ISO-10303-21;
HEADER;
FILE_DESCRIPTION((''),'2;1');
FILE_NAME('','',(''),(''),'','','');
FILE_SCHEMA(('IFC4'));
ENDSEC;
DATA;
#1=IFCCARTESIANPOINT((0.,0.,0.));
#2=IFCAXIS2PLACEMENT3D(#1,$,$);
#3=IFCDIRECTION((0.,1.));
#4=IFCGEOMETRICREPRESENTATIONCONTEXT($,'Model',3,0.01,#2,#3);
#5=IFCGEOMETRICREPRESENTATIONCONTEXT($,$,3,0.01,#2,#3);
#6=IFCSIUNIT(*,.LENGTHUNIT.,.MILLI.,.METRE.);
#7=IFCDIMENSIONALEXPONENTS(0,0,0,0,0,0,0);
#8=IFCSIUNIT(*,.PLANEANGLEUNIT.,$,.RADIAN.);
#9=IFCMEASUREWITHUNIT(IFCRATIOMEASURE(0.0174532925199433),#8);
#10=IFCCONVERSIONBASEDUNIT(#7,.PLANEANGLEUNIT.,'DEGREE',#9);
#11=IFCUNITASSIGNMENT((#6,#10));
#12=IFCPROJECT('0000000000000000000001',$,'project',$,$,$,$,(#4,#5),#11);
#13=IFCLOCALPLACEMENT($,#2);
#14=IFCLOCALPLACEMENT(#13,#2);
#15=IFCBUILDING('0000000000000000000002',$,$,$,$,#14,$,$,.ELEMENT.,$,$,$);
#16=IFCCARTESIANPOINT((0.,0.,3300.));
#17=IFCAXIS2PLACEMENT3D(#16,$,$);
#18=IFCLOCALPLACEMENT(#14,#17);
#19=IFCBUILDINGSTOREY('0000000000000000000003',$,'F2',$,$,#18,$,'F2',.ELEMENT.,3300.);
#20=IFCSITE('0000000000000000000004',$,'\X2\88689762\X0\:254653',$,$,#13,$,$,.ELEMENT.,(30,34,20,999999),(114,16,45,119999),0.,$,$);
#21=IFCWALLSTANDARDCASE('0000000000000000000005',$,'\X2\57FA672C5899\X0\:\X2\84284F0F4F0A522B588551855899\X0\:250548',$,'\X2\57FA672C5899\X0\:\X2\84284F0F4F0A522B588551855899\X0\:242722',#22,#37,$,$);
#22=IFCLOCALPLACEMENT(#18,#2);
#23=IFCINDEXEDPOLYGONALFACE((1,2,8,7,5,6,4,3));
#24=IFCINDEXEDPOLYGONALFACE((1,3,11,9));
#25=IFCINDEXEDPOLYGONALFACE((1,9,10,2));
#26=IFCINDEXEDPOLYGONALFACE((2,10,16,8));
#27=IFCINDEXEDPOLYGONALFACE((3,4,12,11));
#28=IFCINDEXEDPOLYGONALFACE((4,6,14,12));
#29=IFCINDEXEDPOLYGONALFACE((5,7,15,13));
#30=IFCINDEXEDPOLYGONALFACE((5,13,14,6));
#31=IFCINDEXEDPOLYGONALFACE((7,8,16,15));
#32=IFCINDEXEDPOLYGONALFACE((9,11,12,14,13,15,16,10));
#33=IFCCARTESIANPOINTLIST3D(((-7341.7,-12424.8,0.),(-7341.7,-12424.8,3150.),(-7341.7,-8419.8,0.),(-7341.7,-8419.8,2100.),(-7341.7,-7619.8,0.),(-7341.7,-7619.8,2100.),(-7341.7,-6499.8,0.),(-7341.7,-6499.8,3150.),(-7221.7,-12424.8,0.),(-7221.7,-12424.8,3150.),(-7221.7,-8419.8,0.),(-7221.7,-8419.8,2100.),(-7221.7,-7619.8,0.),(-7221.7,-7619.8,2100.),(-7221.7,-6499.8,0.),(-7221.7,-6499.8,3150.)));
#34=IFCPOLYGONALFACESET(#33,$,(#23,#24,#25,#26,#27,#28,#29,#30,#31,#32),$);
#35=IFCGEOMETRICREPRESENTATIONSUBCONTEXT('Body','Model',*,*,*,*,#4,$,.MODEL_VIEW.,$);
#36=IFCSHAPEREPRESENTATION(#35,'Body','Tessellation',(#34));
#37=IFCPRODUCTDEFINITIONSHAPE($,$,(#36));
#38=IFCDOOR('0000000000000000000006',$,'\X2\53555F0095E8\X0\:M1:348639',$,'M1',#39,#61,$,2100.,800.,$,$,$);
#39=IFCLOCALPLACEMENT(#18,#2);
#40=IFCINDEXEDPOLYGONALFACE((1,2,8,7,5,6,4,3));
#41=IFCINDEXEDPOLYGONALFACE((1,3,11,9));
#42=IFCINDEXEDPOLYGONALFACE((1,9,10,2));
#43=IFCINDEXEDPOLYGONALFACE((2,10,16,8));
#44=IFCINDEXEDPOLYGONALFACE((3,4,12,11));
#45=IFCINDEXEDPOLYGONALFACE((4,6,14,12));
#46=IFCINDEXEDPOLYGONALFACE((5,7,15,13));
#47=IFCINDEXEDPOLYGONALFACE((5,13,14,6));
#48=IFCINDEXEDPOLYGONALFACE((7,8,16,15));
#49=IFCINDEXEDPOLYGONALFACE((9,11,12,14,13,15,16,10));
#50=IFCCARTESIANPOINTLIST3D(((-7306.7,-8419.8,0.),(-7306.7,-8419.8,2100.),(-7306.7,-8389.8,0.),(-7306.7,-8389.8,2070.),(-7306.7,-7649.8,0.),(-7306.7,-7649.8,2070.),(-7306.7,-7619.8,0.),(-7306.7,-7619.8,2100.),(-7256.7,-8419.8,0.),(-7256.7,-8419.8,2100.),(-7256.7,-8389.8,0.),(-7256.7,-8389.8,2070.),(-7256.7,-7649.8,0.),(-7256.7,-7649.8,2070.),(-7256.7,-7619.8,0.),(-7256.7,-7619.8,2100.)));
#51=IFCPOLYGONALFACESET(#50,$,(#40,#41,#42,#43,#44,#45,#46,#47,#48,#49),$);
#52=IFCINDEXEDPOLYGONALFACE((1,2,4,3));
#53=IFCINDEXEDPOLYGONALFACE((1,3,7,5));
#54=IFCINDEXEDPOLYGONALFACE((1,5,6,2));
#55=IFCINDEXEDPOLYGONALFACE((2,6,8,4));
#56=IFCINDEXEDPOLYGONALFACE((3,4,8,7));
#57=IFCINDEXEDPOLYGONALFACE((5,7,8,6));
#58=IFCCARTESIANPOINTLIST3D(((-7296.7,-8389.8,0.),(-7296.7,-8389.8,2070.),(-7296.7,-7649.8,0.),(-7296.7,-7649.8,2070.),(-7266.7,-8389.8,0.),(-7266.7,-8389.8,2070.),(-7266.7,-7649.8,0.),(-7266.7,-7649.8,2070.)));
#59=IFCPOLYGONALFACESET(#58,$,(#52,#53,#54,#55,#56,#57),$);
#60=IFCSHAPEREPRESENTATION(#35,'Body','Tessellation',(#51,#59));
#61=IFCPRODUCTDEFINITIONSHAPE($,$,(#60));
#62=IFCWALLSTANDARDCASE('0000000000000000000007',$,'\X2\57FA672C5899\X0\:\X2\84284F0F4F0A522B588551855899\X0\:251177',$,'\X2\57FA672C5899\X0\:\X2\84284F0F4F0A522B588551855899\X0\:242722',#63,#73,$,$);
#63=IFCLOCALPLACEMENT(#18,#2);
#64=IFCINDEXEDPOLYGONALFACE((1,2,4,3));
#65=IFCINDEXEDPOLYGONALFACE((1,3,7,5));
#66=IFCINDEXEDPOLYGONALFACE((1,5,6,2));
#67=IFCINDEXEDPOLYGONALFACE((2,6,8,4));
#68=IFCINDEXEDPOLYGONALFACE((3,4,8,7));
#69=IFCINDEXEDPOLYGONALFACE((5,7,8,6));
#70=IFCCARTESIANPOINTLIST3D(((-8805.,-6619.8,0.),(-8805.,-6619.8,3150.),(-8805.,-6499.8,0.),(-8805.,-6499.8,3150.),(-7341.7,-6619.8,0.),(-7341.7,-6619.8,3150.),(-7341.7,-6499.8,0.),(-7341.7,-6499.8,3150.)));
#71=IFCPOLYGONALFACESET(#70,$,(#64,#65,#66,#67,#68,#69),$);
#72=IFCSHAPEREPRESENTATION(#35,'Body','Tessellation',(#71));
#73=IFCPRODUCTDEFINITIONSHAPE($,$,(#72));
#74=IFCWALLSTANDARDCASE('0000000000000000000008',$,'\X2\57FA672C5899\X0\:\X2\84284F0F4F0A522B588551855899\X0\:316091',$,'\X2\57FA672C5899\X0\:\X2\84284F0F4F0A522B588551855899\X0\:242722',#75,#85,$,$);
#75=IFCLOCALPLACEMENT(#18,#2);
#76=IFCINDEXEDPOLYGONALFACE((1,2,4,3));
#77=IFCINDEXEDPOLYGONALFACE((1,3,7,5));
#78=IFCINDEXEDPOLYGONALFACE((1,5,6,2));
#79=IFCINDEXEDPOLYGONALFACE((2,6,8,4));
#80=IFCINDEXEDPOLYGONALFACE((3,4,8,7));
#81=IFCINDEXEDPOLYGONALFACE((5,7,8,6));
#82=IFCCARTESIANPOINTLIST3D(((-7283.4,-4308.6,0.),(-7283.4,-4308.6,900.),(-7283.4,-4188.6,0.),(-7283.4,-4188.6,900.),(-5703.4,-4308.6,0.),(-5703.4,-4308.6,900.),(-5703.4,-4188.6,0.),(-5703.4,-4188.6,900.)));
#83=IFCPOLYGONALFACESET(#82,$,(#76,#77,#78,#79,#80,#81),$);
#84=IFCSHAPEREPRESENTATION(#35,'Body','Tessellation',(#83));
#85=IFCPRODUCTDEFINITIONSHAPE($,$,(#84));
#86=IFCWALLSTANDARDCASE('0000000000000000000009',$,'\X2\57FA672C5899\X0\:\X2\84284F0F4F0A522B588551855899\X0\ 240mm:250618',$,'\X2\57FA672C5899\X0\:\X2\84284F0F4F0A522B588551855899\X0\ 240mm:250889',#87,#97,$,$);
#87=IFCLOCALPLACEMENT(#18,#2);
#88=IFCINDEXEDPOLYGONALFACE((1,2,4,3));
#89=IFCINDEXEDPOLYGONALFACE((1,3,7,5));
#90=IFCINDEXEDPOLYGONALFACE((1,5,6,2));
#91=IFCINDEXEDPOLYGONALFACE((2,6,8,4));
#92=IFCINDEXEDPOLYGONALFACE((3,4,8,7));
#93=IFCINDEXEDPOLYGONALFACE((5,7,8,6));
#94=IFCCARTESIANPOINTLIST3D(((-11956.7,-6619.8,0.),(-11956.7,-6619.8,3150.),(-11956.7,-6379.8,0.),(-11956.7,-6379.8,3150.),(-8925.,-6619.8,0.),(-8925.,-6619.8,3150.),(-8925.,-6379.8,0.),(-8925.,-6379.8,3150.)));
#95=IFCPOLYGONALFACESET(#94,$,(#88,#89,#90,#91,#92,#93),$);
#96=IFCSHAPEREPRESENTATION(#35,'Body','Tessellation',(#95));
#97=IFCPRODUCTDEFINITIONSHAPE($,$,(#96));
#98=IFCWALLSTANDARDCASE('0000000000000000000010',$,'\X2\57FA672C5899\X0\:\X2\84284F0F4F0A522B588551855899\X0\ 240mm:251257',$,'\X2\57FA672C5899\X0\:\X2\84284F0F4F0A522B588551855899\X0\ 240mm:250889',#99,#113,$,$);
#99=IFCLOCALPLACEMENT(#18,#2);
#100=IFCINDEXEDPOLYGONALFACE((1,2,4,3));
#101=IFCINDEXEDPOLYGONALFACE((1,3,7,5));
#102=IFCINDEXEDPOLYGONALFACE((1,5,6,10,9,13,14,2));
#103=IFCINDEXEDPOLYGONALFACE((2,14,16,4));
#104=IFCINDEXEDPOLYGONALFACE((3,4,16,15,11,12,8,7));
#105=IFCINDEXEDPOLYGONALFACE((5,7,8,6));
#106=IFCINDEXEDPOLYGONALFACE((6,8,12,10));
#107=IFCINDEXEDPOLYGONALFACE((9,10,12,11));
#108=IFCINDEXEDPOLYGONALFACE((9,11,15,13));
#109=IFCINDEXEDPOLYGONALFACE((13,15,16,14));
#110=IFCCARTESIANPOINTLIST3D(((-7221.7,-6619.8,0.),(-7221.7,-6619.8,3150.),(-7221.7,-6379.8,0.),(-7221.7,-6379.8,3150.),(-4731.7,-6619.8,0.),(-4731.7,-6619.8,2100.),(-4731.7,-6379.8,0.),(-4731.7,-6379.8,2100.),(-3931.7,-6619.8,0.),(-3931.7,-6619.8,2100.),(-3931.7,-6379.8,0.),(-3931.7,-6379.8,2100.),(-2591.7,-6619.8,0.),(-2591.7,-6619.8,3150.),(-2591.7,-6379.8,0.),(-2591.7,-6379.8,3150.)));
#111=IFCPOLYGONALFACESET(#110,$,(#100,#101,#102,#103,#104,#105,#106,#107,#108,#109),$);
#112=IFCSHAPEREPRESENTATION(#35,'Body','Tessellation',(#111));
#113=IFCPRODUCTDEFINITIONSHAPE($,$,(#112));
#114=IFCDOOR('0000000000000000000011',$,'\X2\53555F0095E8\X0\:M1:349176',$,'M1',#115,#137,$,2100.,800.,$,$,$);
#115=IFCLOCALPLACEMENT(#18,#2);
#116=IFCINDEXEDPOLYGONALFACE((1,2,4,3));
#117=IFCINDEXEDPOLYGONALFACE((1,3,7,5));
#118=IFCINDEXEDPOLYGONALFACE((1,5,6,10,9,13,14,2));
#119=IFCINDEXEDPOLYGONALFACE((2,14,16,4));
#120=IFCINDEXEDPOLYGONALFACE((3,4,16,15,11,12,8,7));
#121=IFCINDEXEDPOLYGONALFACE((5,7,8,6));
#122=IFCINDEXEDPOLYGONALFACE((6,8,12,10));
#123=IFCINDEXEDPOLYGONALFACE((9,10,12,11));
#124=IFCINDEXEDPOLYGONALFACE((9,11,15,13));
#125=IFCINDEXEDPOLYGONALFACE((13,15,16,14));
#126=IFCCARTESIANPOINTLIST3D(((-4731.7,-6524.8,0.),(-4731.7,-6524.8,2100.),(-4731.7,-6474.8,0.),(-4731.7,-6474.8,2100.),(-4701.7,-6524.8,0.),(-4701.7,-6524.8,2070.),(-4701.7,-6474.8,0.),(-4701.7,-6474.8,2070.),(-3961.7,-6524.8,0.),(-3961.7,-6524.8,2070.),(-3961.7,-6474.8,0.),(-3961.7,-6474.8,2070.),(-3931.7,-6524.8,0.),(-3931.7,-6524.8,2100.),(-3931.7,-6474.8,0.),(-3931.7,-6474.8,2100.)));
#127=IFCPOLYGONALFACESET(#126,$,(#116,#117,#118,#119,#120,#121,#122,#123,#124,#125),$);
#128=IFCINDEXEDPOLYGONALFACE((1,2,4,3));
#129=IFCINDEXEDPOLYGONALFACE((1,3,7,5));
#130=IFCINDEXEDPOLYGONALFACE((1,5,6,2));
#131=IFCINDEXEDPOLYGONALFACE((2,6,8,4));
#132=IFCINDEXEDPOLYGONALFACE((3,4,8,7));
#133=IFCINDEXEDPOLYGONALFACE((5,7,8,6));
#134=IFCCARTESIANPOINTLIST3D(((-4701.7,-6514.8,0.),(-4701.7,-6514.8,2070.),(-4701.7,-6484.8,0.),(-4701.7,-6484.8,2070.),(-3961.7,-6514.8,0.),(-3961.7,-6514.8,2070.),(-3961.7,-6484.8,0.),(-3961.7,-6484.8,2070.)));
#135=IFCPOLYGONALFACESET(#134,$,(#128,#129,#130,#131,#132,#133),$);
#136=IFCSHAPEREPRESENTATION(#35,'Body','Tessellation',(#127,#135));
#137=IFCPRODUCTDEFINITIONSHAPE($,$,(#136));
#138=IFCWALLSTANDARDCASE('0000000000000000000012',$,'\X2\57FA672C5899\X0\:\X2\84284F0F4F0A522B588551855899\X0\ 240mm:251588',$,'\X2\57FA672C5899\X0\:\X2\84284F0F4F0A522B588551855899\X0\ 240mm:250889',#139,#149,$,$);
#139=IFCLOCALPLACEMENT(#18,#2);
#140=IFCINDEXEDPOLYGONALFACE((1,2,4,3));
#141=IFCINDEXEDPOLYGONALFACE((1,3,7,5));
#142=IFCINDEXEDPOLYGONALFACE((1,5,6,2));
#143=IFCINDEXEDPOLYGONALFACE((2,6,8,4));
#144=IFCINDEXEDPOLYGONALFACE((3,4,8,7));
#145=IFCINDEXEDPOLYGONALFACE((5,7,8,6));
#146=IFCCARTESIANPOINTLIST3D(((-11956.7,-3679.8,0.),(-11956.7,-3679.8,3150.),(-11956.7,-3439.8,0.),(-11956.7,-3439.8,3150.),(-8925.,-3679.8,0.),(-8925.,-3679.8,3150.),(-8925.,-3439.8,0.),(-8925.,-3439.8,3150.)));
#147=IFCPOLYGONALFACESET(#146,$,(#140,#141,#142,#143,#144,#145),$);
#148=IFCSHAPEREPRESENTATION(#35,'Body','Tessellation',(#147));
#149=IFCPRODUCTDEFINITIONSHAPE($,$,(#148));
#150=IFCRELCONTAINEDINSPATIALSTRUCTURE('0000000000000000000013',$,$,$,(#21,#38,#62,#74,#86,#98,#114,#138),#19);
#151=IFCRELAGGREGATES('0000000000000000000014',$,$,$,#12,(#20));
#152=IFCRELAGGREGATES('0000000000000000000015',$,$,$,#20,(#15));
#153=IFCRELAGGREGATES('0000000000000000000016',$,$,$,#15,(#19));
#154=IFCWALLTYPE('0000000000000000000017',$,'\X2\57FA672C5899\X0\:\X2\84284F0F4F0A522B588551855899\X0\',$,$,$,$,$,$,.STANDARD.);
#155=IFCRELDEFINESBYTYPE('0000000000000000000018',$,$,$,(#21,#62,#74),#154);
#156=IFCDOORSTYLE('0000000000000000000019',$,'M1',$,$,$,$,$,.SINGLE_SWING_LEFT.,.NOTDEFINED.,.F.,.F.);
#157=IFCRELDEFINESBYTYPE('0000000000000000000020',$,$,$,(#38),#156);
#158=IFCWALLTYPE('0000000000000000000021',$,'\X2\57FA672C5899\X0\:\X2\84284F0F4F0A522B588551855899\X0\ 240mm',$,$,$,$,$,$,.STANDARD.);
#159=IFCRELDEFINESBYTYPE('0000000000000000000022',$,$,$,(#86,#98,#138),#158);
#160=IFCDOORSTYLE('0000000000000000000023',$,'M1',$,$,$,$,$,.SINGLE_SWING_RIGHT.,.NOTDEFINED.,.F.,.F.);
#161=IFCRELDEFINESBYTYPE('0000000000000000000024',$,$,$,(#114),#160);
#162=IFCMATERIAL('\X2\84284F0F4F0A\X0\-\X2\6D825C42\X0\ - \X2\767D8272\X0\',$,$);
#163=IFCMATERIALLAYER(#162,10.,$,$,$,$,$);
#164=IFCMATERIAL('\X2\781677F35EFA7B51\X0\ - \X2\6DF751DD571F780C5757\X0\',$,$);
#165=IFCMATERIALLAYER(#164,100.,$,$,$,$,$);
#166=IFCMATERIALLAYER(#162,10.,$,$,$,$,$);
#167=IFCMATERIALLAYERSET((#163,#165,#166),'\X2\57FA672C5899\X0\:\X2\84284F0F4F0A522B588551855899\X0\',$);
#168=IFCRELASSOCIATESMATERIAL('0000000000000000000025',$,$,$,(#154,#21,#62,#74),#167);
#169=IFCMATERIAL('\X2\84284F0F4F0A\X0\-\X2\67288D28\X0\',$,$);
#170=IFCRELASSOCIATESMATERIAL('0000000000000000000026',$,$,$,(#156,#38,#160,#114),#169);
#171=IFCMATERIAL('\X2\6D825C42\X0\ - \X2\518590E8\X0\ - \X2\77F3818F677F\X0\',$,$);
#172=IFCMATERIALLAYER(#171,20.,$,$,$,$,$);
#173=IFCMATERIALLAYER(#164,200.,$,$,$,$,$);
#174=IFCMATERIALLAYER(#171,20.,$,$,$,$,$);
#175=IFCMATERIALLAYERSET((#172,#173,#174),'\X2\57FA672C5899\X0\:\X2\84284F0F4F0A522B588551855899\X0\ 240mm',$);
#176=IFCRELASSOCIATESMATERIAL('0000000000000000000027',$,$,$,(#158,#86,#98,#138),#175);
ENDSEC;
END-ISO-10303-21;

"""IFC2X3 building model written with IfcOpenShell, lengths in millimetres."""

from ifc_helpers import new_model, entity, si_unit, converted_unit, direction, frame, frame_2d, origin, origin_2d_with_axis, place, context, subcontext, project, spatial, polyline, rectangle, outline, extrude, clip, bounded_halfspace, source, transform, mapped, material, layer, layer_set, layer_usage, type_object, type_shapes, element, fill, save


model = new_model("IFC2X3")

# Units and contexts
model_context = context("Model", 3, precision=0.01, world=origin(), true_north=direction((0.0, 1.0)))
context_of_model = context(None, 3, precision=0.01, world=origin(), true_north=direction((0.0, 1.0)))
body_context = subcontext(model_context, "Body", "Model", "MODEL_VIEW")
ifc_project = project(units=[si_unit("LENGTHUNIT", "METRE", prefix="MILLI"), converted_unit("PLANEANGLEUNIT", "DEGREE", entity("IfcRatioMeasure", 0.0174532925199433), si_unit("PLANEANGLEUNIT", "RADIAN"), dimensions=[0, 0, 0, 0, 0, 0, 0])], contexts=[model_context, context_of_model])

# Site, building, storey
site_placement = place(None, origin())
site = spatial("IfcSite", under=ifc_project, at=site_placement, Name="表面:254653", CompositionType="ELEMENT", RefLatitude=(30, 34, 20, 999999), RefLongitude=(114, 16, 45, 119999), RefElevation=0.0)
building_placement = place(site_placement, origin())
building = spatial("IfcBuilding", under=site, at=building_placement, CompositionType="ELEMENT")
storey_placement = place(building_placement, frame((0.0, 0.0, 3300.0)))
storey = spatial("IfcBuildingStorey", under=building, at=storey_placement, Name="F2", LongName="F2", CompositionType="ELEMENT", Elevation=3300.0)

# Shared definitions
ifc_material_1 = material(Name="萨伏伊-涂层 - 白色")

# Wall, opening, door
ifc_layer_1 = layer(ifc_material_1, 10.0)
ifc_material_2 = material(Name="砖石建筑 - 混凝土砌块")
ifc_layer_2 = layer(ifc_material_2, 100.0)
ifc_layer_3 = layer(ifc_material_1, 10.0)
ifc_layer_set_1 = layer_set([ifc_layer_1, ifc_layer_2, ifc_layer_3], Name="基本墙:萨伏伊别墅内墙")
ifc_layer_usage_1 = layer_usage(ifc_layer_set_1, "AXIS2", "NEGATIVE", 60.0)
wall_type_1 = type_object("IfcWallType", Name="基本墙:萨伏伊别墅内墙", PredefinedType="STANDARD", material=ifc_layer_set_1)
wall_1_placement = place(storey_placement, frame((-7281.7, -6499.8, 0.0), z_axis=(0.0, 0.0, 1.0), x_axis=(0.0, -1.0, 0.0)))
wall_1 = element("IfcWallStandardCase", 1, at=wall_1_placement, inside=storey, type_object=wall_type_1, material=ifc_layer_usage_1, Name="基本墙:萨伏伊别墅内墙:250548", ObjectType="基本墙:萨伏伊别墅内墙:242722", context=body_context, shape_type="Clipping", body=[
    clip(extrude(rectangle(XDim=5925.0, YDim=120.0, at=frame_2d((2962.5, 0.0), x_axis=(-1.0, 0.0))), origin(), (0.0, 0.0, 1.0), 3150.0), bounded_halfspace(frame((0.0, -60.0, 3150.0), z_axis=(0.0, 0.0, -1.0), x_axis=(1.0, 0.0, 0.0)), True, frame((0.0, -60.0, 3150.0)), polyline([(0.0, 0.0), (120.0, 0.0), (5925.0, 0.0), (5925.0, 120.0), (120.0, 120.0), (0.0, 120.0), (0.0, 0.0)]))),
])
opening_1_placement = place(wall_1_placement, frame((1120.0, -60.0, 0.0)))
opening_1 = element("IfcOpeningElement", 2, at=opening_1_placement, cuts=wall_1, ObjectType="Opening", context=body_context, shape_type="SweptSolid", body=[
    extrude(rectangle(XDim=2100.0, YDim=800.0, at=frame_2d((1050.0, 400.0), x_axis=(1.0, 0.0))), frame((0.0, 0.0, 0.0), z_axis=(0.0, 1.0, 0.0), x_axis=(0.0, 0.0, 1.0)), (0.0, 0.0, 1.0), 120.0),
])
ifc_material_3 = material(Name="萨伏伊-木质")
door_style_1 = type_object("IfcDoorStyle", Name="M1", ConstructionType="NOTDEFINED", OperationType="SINGLE_SWING_LEFT", ParameterTakesPrecedence=False, Sizeable=False, material=ifc_material_3)
shared_shape_1 = source(origin(), body_context, "Body", "SweptSolid", [
    extrude(outline(polyline([(-1057.5, -400.0), (1042.5, -400.0), (1042.5, -370.0), (-1027.5, -370.0), (-1027.5, 370.0), (1042.5, 370.0), (1042.5, 400.0), (-1057.5, 400.0), (-1057.5, -400.0)])), frame((400.0, 35.0, 1042.5), z_axis=(0.0, 1.0, 0.0), x_axis=(0.0, 0.0, -1.0)), (0.0, 0.0, 1.0), 50.0),
    extrude(rectangle(XDim=30.0, YDim=740.0, at=origin_2d_with_axis()), frame((400.0, 60.0, 0.0), z_axis=(0.0, 0.0, 1.0), x_axis=(0.0, 1.0, 0.0)), (0.0, 0.0, 1.0), 2070.0),
])
type_shapes(door_style_1, [shared_shape_1])
door_1_placement = place(opening_1_placement, origin())
door_1 = element("IfcDoor", 3, at=door_1_placement, inside=storey, type_object=door_style_1, material=ifc_material_3, Name="单开门:M1:348639", ObjectType="M1", OverallHeight=2100.0, OverallWidth=800.0, context=body_context, shape_type="MappedRepresentation", body=[
    mapped(shared_shape_1, transform((0.0, 0.0, 0.0), scale=1.0)),
])
fill(opening_1, door_1)

# Walls
ifc_layer_usage_2 = layer_usage(ifc_layer_set_1, "AXIS2", "NEGATIVE", 60.0)
wall_2_placement = place(storey_placement, frame((-8805.0, -6559.8, 0.0)))
element("IfcWallStandardCase", 4, at=wall_2_placement, inside=storey, type_object=wall_type_1, material=ifc_layer_usage_2, Name="基本墙:萨伏伊别墅内墙:251177", ObjectType="基本墙:萨伏伊别墅内墙:242722", context=body_context, shape_type="Clipping", body=[
    clip(extrude(rectangle(XDim=1463.3, YDim=120.0, at=frame_2d((731.7, 0.0), x_axis=(-1.0, 0.0))), origin(), (0.0, 0.0, 1.0), 3150.0), bounded_halfspace(frame((0.0, -60.0, 3150.0), z_axis=(0.0, 0.0, -1.0), x_axis=(0.0, -1.0, 0.0)), True, frame((0.0, -60.0, 3150.0)), polyline([(0.0, 0.0), (1463.3, 0.0), (1463.3, 120.0), (0.0, 120.0), (0.0, 0.0)]))),
])
ifc_layer_usage_3 = layer_usage(ifc_layer_set_1, "AXIS2", "NEGATIVE", 60.0)
wall_3_placement = place(storey_placement, frame((-5703.4, -4248.6, 0.0), z_axis=(0.0, 0.0, 1.0), x_axis=(-1.0, 0.0, 0.0)))
element("IfcWallStandardCase", 5, at=wall_3_placement, inside=storey, type_object=wall_type_1, material=ifc_layer_usage_3, Name="基本墙:萨伏伊别墅内墙:316091", ObjectType="基本墙:萨伏伊别墅内墙:242722", context=body_context, shape_type="SweptSolid", body=[
    extrude(rectangle(XDim=1580.0, YDim=120.0, at=frame_2d((790.0, 0.0), x_axis=(-1.0, 0.0))), origin(), (0.0, 0.0, 1.0), 900.0),
])

# Wall
ifc_material_4 = material(Name="涂层 - 内部 - 石膏板")
ifc_layer_4 = layer(ifc_material_4, 20.0)
ifc_layer_5 = layer(ifc_material_2, 200.0)
ifc_layer_6 = layer(ifc_material_4, 20.0)
ifc_layer_set_2 = layer_set([ifc_layer_4, ifc_layer_5, ifc_layer_6], Name="基本墙:萨伏伊别墅内墙 240mm")
ifc_layer_usage_4 = layer_usage(ifc_layer_set_2, "AXIS2", "NEGATIVE", 120.0)
wall_type_2 = type_object("IfcWallType", Name="基本墙:萨伏伊别墅内墙 240mm", PredefinedType="STANDARD", material=ifc_layer_set_2)
wall_4_placement = place(storey_placement, frame((-8925.0, -6499.8, 0.0), z_axis=(0.0, 0.0, 1.0), x_axis=(-1.0, 0.0, 0.0)))
element("IfcWallStandardCase", 6, at=wall_4_placement, inside=storey, type_object=wall_type_2, material=ifc_layer_usage_4, Name="基本墙:萨伏伊别墅内墙 240mm:250618", ObjectType="基本墙:萨伏伊别墅内墙 240mm:250889", context=body_context, shape_type="Clipping", body=[
    clip(extrude(rectangle(XDim=3031.7, YDim=240.0, at=frame_2d((1515.8, 0.0), x_axis=(-1.0, 0.0))), origin(), (0.0, 0.0, 1.0), 3150.0), bounded_halfspace(frame((3031.7, -60.0, 3150.0), z_axis=(0.0, 0.0, -1.0), x_axis=(0.0, 1.0, 0.0)), True, frame((3031.7, -60.0, 3150.0)), polyline([(0.0, 0.0), (0.0, 180.0), (-3031.7, 180.0), (-3031.7, 0.0), (0.0, 0.0)]))),
])

# Wall, opening, door
ifc_layer_usage_5 = layer_usage(ifc_layer_set_2, "AXIS2", "NEGATIVE", 120.0)
wall_5_placement = place(storey_placement, frame((-7221.7, -6499.8, 0.0)))
wall_5 = element("IfcWallStandardCase", 7, at=wall_5_placement, inside=storey, type_object=wall_type_2, material=ifc_layer_usage_5, Name="基本墙:萨伏伊别墅内墙 240mm:251257", ObjectType="基本墙:萨伏伊别墅内墙 240mm:250889", context=body_context, shape_type="Clipping", body=[
    clip(extrude(rectangle(XDim=4630.0, YDim=240.0, at=frame_2d((2315.0, 0.0), x_axis=(-1.0, 0.0))), origin(), (0.0, 0.0, 1.0), 3150.0), bounded_halfspace(frame((0.0, -120.0, 3150.0), z_axis=(0.0, 0.0, -1.0), x_axis=(0.0, -1.0, 0.0)), True, frame((0.0, -120.0, 3150.0)), polyline([(0.0, 0.0), (4630.0, 0.0), (4630.0, 240.0), (0.0, 240.0), (0.0, 120.0), (0.0, 0.0)]))),
])
opening_2_placement = place(wall_5_placement, frame((2490.0, -120.0, 0.0)))
opening_2 = element("IfcOpeningElement", 8, at=opening_2_placement, cuts=wall_5, ObjectType="Opening", context=body_context, shape_type="SweptSolid", body=[
    extrude(rectangle(XDim=2100.0, YDim=800.0, at=frame_2d((1050.0, 400.0), x_axis=(1.0, 0.0))), frame((0.0, 0.0, 0.0), z_axis=(0.0, 1.0, 0.0), x_axis=(0.0, 0.0, 1.0)), (0.0, 0.0, 1.0), 240.0),
])
door_style_2 = type_object("IfcDoorStyle", Name="M1", ConstructionType="NOTDEFINED", OperationType="SINGLE_SWING_RIGHT", ParameterTakesPrecedence=False, Sizeable=False, material=ifc_material_3)
shared_shape_2 = source(origin(), body_context, "Body", "SweptSolid", [
    extrude(outline(polyline([(-1057.5, -400.0), (1042.5, -400.0), (1042.5, -370.0), (-1027.5, -370.0), (-1027.5, 370.0), (1042.5, 370.0), (1042.5, 400.0), (-1057.5, 400.0), (-1057.5, -400.0)])), frame((400.0, 145.0, 1042.5), z_axis=(0.0, -1.0, 0.0), x_axis=(0.0, 0.0, -1.0)), (0.0, 0.0, 1.0), 50.0),
    extrude(rectangle(XDim=740.0, YDim=30.0, at=origin_2d_with_axis()), frame((400.0, 120.0, 0.0)), (0.0, 0.0, 1.0), 2070.0),
])
type_shapes(door_style_2, [shared_shape_2])
door_2_placement = place(opening_2_placement, origin())
door_2 = element("IfcDoor", 9, at=door_2_placement, inside=storey, type_object=door_style_2, material=ifc_material_3, Name="单开门:M1:349176", ObjectType="M1", OverallHeight=2100.0, OverallWidth=800.0, context=body_context, shape_type="MappedRepresentation", body=[
    mapped(shared_shape_2, transform((0.0, 0.0, 0.0), scale=1.0)),
])
fill(opening_2, door_2)

# Wall
ifc_layer_usage_6 = layer_usage(ifc_layer_set_2, "AXIS2", "NEGATIVE", 120.0)
wall_6_placement = place(storey_placement, frame((-8925.0, -3559.8, 0.0), z_axis=(0.0, 0.0, 1.0), x_axis=(-1.0, 0.0, 0.0)))
element("IfcWallStandardCase", 10, at=wall_6_placement, inside=storey, type_object=wall_type_2, material=ifc_layer_usage_6, Name="基本墙:萨伏伊别墅内墙 240mm:251588", ObjectType="基本墙:萨伏伊别墅内墙 240mm:250889", context=body_context, shape_type="Clipping", body=[
    clip(extrude(rectangle(XDim=3031.7, YDim=240.0, at=frame_2d((1515.8, 0.0), x_axis=(-1.0, 0.0))), origin(), (0.0, 0.0, 1.0), 3150.0), bounded_halfspace(frame((0.0, -120.0, 3150.0), z_axis=(0.0, 0.0, -1.0), x_axis=(0.0, 1.0, 0.0)), True, frame((0.0, -120.0, 3150.0)), polyline([(0.0, 0.0), (3031.7, 0.0), (3031.7, 180.0), (0.0, 180.0), (0.0, 0.0)]))),
])

save(model, "model.ifc")
